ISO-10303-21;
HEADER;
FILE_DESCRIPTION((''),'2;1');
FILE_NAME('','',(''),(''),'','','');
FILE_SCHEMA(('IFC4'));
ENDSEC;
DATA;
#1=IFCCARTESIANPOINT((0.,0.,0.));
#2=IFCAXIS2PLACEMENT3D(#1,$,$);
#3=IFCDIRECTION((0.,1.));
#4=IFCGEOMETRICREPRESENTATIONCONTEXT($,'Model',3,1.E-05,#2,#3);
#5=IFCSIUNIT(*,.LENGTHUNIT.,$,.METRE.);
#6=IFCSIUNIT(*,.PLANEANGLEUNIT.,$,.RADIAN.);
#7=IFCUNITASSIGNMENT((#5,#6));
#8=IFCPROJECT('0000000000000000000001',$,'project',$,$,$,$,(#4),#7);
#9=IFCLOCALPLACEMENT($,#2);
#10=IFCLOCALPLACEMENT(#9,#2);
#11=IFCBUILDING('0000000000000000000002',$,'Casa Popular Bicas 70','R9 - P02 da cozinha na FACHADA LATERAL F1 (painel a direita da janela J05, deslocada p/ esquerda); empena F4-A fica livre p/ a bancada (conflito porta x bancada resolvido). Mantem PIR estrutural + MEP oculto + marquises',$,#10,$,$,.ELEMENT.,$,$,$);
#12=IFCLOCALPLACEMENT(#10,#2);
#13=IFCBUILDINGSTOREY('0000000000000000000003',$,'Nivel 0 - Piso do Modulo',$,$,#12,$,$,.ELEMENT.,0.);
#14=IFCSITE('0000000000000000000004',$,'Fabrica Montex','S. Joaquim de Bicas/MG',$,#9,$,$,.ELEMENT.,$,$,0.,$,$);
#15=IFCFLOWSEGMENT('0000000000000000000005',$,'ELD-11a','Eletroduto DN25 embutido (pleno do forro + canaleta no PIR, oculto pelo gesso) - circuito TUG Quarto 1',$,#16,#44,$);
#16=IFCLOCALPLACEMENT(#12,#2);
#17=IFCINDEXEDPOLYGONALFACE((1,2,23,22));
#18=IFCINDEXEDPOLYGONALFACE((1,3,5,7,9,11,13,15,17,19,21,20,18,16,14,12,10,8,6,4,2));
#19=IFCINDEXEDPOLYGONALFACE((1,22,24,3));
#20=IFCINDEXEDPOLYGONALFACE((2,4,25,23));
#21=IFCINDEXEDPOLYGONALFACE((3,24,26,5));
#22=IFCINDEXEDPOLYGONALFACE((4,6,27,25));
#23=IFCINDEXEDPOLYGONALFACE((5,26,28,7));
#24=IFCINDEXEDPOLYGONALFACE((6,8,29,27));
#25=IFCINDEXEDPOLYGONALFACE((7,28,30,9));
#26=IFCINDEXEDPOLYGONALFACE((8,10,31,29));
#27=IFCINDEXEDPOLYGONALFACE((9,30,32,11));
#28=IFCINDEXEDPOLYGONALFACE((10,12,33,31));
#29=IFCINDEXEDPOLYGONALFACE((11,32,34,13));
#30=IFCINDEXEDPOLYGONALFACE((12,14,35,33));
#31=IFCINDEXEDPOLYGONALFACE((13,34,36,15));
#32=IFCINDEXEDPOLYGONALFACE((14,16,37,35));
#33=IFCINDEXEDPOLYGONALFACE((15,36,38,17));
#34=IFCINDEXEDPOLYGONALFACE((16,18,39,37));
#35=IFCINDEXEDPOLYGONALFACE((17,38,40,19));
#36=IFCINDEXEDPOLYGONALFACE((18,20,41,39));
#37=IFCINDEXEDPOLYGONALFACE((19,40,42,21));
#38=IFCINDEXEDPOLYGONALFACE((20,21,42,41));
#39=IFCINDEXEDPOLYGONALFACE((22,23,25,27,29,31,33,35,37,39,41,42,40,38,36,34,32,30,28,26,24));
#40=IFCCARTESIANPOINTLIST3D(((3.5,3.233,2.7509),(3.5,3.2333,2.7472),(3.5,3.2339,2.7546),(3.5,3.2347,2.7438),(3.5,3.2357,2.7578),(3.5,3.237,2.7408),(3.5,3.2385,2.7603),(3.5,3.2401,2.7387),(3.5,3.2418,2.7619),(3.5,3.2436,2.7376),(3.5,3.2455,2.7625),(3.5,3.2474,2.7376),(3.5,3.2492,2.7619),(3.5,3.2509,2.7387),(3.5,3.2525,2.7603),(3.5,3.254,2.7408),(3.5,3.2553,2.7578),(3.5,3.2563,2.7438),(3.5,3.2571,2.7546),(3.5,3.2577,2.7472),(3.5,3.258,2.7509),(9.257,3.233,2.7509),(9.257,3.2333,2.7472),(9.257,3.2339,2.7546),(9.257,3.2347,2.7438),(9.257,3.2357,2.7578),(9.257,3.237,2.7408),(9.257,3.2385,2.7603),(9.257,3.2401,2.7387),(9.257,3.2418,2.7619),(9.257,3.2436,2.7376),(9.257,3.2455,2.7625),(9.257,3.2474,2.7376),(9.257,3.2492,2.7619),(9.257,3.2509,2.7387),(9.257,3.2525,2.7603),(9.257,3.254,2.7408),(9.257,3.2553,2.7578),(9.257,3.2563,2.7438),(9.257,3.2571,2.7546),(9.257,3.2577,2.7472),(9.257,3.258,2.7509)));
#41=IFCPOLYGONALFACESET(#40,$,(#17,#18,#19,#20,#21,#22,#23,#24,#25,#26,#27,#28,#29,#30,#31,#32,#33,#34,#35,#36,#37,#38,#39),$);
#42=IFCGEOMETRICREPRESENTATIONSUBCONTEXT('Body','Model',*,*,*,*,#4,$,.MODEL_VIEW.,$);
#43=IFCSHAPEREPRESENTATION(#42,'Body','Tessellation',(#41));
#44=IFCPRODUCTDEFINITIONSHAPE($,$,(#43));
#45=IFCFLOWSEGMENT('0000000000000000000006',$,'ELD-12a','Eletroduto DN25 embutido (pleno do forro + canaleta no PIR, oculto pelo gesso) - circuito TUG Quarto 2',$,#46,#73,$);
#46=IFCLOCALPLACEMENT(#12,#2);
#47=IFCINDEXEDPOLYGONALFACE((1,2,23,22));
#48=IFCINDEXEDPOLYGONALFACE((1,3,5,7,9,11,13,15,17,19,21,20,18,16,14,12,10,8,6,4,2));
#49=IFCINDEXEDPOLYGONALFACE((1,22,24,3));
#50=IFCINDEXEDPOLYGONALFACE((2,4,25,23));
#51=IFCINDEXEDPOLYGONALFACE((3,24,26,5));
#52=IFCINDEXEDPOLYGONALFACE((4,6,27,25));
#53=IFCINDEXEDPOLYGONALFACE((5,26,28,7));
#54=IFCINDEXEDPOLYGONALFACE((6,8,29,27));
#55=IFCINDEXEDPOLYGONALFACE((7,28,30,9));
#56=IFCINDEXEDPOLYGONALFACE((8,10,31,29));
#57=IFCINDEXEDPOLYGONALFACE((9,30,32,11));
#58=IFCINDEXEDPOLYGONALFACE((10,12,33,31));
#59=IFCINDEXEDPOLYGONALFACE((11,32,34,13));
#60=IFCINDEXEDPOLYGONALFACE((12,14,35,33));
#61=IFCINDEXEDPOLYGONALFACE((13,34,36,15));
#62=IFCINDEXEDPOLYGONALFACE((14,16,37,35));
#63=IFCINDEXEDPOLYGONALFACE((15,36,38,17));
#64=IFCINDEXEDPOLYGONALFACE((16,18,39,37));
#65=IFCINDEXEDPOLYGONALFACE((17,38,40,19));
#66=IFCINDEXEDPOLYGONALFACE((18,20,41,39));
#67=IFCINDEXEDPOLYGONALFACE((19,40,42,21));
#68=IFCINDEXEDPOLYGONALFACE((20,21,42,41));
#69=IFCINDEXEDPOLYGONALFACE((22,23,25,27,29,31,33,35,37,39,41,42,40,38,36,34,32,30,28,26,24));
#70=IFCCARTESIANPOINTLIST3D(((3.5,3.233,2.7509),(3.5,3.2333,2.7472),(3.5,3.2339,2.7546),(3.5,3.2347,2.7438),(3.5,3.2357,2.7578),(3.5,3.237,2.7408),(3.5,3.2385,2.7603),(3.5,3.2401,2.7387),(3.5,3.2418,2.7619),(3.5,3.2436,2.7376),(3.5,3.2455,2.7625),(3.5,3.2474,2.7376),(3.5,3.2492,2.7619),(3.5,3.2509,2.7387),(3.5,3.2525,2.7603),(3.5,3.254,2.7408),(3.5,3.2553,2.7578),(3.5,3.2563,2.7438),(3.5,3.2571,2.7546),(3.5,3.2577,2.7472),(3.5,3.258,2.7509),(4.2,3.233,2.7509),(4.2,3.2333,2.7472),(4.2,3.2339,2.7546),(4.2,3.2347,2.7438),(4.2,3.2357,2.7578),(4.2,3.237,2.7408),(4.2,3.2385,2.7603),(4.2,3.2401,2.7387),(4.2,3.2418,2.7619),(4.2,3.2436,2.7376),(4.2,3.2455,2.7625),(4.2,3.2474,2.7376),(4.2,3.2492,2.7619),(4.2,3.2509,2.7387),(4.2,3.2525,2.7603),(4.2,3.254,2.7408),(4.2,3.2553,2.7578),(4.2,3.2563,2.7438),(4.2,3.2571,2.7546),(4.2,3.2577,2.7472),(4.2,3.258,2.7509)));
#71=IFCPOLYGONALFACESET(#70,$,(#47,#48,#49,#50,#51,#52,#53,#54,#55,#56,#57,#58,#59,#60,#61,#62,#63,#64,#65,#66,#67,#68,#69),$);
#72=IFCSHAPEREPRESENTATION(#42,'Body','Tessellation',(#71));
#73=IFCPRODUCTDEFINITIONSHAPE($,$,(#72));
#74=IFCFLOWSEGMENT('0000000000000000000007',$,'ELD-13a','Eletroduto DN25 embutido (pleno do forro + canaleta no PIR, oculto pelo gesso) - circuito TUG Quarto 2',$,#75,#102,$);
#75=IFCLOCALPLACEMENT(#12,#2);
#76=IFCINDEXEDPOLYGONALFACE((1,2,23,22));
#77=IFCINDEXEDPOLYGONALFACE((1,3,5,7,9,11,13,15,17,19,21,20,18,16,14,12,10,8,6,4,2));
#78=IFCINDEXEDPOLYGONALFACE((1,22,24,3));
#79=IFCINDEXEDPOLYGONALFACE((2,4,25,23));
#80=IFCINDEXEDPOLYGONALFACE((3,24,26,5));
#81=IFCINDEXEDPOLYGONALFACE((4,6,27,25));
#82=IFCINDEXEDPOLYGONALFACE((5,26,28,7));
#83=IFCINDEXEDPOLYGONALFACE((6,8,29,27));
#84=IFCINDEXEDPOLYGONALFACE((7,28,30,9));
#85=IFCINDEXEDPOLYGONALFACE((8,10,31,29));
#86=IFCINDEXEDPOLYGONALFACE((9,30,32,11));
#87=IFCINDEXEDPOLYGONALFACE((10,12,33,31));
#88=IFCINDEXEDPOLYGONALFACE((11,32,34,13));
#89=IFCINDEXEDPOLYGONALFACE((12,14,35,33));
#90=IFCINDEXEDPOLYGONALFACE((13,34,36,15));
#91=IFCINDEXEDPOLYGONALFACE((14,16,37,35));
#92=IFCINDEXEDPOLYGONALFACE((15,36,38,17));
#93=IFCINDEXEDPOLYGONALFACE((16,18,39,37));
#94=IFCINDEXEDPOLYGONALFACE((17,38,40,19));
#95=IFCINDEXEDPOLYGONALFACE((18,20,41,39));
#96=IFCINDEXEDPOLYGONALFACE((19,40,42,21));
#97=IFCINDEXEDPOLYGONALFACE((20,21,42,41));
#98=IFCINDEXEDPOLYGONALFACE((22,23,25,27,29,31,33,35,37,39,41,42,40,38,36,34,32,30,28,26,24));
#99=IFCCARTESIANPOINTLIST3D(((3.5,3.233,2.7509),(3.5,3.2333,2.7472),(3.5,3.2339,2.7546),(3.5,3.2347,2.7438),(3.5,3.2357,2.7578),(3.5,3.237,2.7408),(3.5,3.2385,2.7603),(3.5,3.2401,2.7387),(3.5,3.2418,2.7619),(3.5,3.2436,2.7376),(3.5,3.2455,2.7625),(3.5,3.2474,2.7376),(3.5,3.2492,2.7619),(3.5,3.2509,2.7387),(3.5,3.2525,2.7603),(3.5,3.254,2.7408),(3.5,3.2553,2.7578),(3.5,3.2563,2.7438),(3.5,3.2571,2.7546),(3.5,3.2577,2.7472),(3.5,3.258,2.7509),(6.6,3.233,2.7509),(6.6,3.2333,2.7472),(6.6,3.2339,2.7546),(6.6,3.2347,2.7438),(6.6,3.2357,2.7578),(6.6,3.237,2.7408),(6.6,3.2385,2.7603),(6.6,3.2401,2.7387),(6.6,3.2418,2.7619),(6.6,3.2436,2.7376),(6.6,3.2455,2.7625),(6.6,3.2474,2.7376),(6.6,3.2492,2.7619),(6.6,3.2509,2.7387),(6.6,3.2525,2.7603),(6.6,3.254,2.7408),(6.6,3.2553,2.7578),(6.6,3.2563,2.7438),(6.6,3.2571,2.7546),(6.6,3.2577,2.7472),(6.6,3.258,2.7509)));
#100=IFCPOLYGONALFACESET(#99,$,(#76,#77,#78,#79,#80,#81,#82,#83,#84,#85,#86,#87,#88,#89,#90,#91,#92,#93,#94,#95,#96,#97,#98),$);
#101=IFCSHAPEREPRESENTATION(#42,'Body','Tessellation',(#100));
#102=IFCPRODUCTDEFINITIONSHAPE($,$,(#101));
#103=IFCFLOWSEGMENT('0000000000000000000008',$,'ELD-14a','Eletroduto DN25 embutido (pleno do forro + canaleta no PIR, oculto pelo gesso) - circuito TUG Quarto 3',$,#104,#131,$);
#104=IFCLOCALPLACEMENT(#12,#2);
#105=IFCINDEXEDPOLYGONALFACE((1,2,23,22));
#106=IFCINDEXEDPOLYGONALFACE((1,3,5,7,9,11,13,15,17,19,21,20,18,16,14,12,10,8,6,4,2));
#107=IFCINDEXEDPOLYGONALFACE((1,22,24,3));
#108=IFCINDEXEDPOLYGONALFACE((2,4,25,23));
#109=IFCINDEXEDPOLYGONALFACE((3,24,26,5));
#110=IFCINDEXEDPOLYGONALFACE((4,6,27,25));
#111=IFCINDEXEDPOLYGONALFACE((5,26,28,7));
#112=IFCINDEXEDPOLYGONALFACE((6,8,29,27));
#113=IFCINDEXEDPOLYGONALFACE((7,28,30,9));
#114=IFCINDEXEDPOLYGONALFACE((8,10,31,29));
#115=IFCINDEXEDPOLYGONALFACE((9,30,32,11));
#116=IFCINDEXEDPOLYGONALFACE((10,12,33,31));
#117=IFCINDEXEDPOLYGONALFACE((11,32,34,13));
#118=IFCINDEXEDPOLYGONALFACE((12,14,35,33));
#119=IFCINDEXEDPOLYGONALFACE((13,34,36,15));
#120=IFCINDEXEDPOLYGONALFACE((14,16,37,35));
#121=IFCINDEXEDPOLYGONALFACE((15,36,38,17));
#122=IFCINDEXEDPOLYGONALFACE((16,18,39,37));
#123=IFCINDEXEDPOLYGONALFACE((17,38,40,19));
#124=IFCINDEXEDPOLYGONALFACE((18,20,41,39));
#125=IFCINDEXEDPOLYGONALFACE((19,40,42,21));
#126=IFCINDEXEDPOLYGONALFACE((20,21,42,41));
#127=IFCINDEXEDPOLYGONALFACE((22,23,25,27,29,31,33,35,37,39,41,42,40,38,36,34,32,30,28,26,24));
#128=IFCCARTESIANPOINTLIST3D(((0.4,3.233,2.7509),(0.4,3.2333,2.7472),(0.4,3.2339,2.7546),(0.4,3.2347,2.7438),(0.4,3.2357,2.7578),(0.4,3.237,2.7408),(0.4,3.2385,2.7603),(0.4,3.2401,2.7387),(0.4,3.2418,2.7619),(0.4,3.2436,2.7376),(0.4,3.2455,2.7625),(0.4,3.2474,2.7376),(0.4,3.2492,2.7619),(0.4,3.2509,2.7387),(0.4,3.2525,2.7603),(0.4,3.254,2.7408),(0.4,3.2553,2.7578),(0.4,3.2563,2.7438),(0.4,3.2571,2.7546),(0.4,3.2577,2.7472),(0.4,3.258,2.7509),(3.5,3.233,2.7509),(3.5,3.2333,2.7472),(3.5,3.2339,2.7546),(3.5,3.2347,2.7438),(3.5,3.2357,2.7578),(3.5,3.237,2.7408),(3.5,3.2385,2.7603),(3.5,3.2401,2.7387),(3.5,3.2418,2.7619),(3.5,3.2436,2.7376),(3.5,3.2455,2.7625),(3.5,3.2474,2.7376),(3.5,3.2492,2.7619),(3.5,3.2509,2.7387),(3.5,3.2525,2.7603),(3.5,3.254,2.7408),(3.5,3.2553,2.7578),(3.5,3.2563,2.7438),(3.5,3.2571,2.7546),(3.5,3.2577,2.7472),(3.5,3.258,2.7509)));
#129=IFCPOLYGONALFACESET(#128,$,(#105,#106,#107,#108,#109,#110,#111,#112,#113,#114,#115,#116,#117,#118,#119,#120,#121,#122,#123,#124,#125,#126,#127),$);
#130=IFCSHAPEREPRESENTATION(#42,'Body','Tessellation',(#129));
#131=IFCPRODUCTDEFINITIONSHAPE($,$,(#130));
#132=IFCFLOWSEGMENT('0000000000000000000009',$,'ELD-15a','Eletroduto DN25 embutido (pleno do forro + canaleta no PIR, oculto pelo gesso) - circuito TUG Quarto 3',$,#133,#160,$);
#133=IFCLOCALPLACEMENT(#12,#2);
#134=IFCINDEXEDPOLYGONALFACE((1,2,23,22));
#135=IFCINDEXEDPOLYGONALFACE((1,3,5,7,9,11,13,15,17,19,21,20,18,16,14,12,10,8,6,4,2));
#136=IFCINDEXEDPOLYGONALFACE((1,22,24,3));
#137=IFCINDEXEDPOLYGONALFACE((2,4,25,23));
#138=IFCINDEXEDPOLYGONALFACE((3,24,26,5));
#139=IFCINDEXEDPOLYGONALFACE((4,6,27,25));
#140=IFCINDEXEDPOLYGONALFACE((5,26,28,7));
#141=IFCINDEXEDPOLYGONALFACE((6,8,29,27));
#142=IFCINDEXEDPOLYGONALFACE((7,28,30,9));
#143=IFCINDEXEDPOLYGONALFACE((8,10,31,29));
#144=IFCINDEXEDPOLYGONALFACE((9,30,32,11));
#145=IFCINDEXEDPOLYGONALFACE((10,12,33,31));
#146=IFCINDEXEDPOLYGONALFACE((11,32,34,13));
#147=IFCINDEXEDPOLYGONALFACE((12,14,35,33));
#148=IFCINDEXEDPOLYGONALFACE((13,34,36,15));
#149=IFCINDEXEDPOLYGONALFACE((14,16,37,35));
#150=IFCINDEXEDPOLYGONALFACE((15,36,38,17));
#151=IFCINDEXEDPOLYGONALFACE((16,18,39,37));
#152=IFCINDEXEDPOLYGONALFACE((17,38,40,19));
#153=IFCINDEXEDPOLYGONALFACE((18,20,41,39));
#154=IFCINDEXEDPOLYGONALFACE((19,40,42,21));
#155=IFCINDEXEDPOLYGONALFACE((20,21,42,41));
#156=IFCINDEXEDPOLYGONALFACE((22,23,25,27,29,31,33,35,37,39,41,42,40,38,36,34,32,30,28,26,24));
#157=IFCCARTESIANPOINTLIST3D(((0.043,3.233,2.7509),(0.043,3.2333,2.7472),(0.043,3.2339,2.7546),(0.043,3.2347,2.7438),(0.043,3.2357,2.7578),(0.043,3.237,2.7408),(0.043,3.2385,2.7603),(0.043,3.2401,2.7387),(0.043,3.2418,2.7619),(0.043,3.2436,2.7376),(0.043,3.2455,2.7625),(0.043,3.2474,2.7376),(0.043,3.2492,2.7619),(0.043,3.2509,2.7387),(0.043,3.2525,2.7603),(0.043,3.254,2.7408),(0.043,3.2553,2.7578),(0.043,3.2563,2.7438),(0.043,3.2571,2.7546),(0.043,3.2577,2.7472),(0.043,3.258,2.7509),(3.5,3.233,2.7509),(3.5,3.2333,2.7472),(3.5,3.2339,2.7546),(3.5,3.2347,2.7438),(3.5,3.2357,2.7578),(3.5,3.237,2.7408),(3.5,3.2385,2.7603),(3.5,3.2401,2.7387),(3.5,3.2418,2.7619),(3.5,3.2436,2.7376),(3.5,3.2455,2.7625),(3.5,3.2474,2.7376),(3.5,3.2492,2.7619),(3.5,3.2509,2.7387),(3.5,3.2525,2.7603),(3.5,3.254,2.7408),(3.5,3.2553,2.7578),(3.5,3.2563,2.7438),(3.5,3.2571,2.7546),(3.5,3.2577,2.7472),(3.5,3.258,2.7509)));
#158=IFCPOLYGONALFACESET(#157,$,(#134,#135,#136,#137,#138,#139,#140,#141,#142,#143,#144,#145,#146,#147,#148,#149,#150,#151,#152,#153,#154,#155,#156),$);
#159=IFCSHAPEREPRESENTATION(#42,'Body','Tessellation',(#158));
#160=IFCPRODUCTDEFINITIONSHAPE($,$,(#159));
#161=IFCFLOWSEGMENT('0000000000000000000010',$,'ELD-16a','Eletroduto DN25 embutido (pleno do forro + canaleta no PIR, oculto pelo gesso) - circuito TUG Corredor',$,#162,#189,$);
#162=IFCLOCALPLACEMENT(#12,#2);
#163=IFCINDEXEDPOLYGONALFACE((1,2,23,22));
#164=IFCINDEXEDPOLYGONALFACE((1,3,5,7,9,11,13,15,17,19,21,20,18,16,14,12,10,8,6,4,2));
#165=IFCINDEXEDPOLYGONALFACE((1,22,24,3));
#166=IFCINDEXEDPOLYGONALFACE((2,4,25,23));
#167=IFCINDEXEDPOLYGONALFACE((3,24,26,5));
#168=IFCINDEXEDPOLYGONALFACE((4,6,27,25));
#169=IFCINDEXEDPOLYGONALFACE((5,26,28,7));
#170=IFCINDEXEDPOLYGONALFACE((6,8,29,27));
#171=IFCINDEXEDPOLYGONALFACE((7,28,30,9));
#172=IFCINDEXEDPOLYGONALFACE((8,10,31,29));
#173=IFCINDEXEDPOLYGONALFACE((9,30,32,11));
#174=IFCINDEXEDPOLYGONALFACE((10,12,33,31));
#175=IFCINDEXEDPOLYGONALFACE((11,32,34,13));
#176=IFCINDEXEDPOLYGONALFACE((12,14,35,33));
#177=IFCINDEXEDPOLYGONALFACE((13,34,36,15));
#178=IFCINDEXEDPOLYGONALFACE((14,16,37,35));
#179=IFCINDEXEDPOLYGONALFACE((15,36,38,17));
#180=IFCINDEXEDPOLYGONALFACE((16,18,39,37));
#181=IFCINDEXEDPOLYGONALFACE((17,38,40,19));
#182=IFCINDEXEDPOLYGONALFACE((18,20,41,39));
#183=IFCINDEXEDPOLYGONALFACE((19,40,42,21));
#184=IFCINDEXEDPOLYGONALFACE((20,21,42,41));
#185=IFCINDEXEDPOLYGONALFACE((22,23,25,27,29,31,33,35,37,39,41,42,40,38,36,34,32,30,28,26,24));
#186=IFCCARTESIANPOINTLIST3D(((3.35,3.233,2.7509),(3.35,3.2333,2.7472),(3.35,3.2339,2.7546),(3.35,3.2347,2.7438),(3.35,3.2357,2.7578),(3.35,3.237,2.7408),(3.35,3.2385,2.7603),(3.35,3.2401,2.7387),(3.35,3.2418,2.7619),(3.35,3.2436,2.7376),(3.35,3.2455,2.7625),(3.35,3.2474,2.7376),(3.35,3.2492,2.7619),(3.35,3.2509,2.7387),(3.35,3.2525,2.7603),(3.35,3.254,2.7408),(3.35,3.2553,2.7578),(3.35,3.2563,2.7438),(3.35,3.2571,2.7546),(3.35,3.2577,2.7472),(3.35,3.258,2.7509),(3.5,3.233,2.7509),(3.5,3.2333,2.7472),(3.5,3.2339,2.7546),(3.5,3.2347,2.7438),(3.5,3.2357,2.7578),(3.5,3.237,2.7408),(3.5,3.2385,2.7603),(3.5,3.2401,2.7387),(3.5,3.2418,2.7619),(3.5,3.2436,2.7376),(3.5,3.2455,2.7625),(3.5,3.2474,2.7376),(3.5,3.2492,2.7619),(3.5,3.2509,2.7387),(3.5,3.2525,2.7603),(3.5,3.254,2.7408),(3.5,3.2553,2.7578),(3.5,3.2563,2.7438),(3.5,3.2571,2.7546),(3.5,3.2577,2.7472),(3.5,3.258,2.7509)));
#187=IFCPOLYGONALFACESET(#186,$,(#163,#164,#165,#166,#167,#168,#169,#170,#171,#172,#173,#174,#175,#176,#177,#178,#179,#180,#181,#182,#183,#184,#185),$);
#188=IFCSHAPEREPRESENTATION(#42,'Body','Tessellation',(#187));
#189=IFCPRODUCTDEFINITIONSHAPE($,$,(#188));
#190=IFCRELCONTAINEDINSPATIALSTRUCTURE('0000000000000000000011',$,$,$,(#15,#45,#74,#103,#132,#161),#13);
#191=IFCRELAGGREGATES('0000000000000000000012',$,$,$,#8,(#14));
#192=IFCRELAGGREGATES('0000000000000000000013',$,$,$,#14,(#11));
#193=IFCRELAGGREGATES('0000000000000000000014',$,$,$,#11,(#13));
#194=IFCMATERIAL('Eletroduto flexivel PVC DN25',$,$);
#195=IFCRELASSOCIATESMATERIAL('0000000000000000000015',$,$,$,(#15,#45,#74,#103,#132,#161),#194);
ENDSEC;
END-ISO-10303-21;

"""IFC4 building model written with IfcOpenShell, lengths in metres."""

from ifc_helpers import new_model, si_unit, direction, frame, origin, origin_2d, place, context, subcontext, project, spatial, circle, extrude, material, element, save


model = new_model("IFC4")

# Units and contexts
model_context = context("Model", 3, precision=1e-05, world=origin(), true_north=direction((0.0, 1.0)))
body_context = subcontext(model_context, "Body", "Model", "MODEL_VIEW")
ifc_project = project(units=[si_unit("LENGTHUNIT", "METRE"), si_unit("PLANEANGLEUNIT", "RADIAN")], contexts=[model_context])

# Site, building, storey
site_placement = place(None, origin())
site = spatial("IfcSite", under=ifc_project, at=site_placement, Name="Fabrica Montex", Description="S. Joaquim de Bicas/MG", CompositionType="ELEMENT", RefElevation=0.0)
building_placement = place(site_placement, origin())
building = spatial("IfcBuilding", under=site, at=building_placement, Name="Casa Popular Bicas 70", Description="R9 - P02 da cozinha na FACHADA LATERAL F1 (painel a direita da janela J05, deslocada p/ esquerda); empena F4-A fica livre p/ a bancada (conflito porta x bancada resolvido). Mantem PIR estrutural + MEP oculto + marquises", CompositionType="ELEMENT")
storey_placement = place(building_placement, origin())
storey = spatial("IfcBuildingStorey", under=building, at=storey_placement, Name="Nivel 0 - Piso do Modulo", CompositionType="ELEMENT", Elevation=0.0)

# Flow segments
ifc_material_1 = material(Name="Eletroduto flexivel PVC DN25")
flow_segment_1_placement = place(storey_placement, frame((3.5, 3.2455, 2.75), z_axis=(1.0, 0.0, 0.0), x_axis=(0.0, 0.0, 1.0)))
element("IfcFlowSegment", 1, at=flow_segment_1_placement, inside=storey, material=ifc_material_1, Name="ELD-11a", Description="Eletroduto DN25 embutido (pleno do forro + canaleta no PIR, oculto pelo gesso) - circuito TUG Quarto 1", context=body_context, shape_type="SweptSolid", body=[
    extrude(circle(Radius=0.0125, at=origin_2d()), origin(), (0.0, 0.0, 1.0), 5.757),
])
flow_segment_2_placement = place(storey_placement, frame((3.5, 3.2455, 2.75), z_axis=(1.0, 0.0, 0.0), x_axis=(0.0, 0.0, 1.0)))
element("IfcFlowSegment", 2, at=flow_segment_2_placement, inside=storey, material=ifc_material_1, Name="ELD-12a", Description="Eletroduto DN25 embutido (pleno do forro + canaleta no PIR, oculto pelo gesso) - circuito TUG Quarto 2", context=body_context, shape_type="SweptSolid", body=[
    extrude(circle(Radius=0.0125, at=origin_2d()), origin(), (0.0, 0.0, 1.0), 0.7),
])
flow_segment_3_placement = place(storey_placement, frame((3.5, 3.2455, 2.75), z_axis=(1.0, 0.0, 0.0), x_axis=(0.0, 0.0, 1.0)))
element("IfcFlowSegment", 3, at=flow_segment_3_placement, inside=storey, material=ifc_material_1, Name="ELD-13a", Description="Eletroduto DN25 embutido (pleno do forro + canaleta no PIR, oculto pelo gesso) - circuito TUG Quarto 2", context=body_context, shape_type="SweptSolid", body=[
    extrude(circle(Radius=0.0125, at=origin_2d()), origin(), (0.0, 0.0, 1.0), 3.1),
])
flow_segment_4_placement = place(storey_placement, frame((3.5, 3.2455, 2.75), z_axis=(-1.0, 0.0, 0.0), x_axis=(0.0, 0.0, 1.0)))
element("IfcFlowSegment", 4, at=flow_segment_4_placement, inside=storey, material=ifc_material_1, Name="ELD-14a", Description="Eletroduto DN25 embutido (pleno do forro + canaleta no PIR, oculto pelo gesso) - circuito TUG Quarto 3", context=body_context, shape_type="SweptSolid", body=[
    extrude(circle(Radius=0.0125, at=origin_2d()), origin(), (0.0, 0.0, 1.0), 3.1),
])
flow_segment_5_placement = place(storey_placement, frame((3.5, 3.2455, 2.75), z_axis=(-1.0, 0.0, 0.0), x_axis=(0.0, 0.0, 1.0)))
element("IfcFlowSegment", 5, at=flow_segment_5_placement, inside=storey, material=ifc_material_1, Name="ELD-15a", Description="Eletroduto DN25 embutido (pleno do forro + canaleta no PIR, oculto pelo gesso) - circuito TUG Quarto 3", context=body_context, shape_type="SweptSolid", body=[
    extrude(circle(Radius=0.0125, at=origin_2d()), origin(), (0.0, 0.0, 1.0), 3.457),
])
flow_segment_6_placement = place(storey_placement, frame((3.5, 3.2455, 2.75), z_axis=(-1.0, 0.0, 0.0), x_axis=(0.0, 0.0, 1.0)))
element("IfcFlowSegment", 6, at=flow_segment_6_placement, inside=storey, material=ifc_material_1, Name="ELD-16a", Description="Eletroduto DN25 embutido (pleno do forro + canaleta no PIR, oculto pelo gesso) - circuito TUG Corredor", context=body_context, shape_type="SweptSolid", body=[
    extrude(circle(Radius=0.0125, at=origin_2d()), origin(), (0.0, 0.0, 1.0), 0.15),
])

save(model, "model.ifc")
